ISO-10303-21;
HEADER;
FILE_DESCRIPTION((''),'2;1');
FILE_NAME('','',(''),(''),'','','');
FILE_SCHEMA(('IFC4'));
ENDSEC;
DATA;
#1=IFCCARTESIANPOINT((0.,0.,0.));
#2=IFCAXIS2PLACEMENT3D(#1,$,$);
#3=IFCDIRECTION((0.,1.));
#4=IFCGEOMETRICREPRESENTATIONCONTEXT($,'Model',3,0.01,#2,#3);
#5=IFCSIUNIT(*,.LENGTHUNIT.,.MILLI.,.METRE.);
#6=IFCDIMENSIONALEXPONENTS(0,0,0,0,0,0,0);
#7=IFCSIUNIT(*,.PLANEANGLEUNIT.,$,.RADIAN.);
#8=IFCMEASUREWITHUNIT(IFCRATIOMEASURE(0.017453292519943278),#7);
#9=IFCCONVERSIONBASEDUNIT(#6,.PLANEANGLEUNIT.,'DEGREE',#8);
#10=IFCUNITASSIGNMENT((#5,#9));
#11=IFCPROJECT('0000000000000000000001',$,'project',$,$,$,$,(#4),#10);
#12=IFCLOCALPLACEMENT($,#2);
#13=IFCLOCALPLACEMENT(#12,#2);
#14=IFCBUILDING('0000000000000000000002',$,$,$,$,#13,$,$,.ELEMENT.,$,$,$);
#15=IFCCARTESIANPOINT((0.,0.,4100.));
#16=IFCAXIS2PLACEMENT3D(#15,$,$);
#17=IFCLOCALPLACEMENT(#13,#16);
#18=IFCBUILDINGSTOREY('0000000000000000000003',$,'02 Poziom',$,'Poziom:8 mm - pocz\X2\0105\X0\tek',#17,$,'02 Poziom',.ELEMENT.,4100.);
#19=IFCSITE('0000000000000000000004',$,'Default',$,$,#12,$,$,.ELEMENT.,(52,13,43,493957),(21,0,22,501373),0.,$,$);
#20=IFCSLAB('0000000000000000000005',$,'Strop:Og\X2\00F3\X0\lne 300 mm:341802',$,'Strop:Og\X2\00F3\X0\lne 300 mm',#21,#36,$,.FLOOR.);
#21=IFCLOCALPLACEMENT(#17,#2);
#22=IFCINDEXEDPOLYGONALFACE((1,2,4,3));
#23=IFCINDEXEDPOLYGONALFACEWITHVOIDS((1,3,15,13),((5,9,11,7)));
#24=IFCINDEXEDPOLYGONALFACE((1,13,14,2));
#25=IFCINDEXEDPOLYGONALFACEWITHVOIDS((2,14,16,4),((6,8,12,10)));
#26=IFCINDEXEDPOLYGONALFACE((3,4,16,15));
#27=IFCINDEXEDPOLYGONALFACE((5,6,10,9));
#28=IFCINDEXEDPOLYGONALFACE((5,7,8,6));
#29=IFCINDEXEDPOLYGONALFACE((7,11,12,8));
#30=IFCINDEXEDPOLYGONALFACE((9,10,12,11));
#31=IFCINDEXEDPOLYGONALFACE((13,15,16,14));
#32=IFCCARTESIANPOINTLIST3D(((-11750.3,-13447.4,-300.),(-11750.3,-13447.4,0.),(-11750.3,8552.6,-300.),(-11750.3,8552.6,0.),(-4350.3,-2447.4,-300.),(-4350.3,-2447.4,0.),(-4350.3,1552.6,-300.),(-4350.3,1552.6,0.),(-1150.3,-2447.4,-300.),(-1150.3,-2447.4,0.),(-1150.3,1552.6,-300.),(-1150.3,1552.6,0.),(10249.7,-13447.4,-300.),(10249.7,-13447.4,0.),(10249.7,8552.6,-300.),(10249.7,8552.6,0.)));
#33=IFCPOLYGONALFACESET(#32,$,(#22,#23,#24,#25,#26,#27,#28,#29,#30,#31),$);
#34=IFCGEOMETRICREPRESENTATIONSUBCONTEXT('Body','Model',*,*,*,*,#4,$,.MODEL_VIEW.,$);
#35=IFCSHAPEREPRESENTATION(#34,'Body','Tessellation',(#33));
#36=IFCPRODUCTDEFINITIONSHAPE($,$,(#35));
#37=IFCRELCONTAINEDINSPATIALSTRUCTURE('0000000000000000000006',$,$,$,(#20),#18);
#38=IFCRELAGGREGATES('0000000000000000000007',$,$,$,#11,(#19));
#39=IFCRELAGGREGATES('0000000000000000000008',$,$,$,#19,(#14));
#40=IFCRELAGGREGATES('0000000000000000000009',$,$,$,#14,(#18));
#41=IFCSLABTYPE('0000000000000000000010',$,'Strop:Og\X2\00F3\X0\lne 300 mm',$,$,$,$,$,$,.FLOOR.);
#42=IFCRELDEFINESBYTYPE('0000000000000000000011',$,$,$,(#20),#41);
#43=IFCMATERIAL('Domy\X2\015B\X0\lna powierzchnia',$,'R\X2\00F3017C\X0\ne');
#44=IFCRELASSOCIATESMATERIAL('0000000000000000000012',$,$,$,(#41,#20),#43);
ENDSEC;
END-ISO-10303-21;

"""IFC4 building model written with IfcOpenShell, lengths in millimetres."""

from ifc_helpers import new_model, entity, si_unit, converted_unit, direction, frame, origin, place, context, subcontext, project, spatial, indexed_curve, outline, extrude, material, type_object, element, save


model = new_model("IFC4")

# Units and contexts
model_context = context("Model", 3, precision=0.01, world=origin(), true_north=direction((0.0, 1.0)))
body_context = subcontext(model_context, "Body", "Model", "MODEL_VIEW")
ifc_project = project(units=[si_unit("LENGTHUNIT", "METRE", prefix="MILLI"), converted_unit("PLANEANGLEUNIT", "DEGREE", entity("IfcRatioMeasure", 0.017453292519943278), si_unit("PLANEANGLEUNIT", "RADIAN"), dimensions=[0, 0, 0, 0, 0, 0, 0])], contexts=[model_context])

# Site, building, storey
site_placement = place(None, origin())
site = spatial("IfcSite", under=ifc_project, at=site_placement, Name="Default", CompositionType="ELEMENT", RefLatitude=(52, 13, 43, 493957), RefLongitude=(21, 0, 22, 501373), RefElevation=0.0)
building_placement = place(site_placement, origin())
building = spatial("IfcBuilding", under=site, at=building_placement, CompositionType="ELEMENT")
storey_placement = place(building_placement, frame((0.0, 0.0, 4100.0)))
storey = spatial("IfcBuildingStorey", under=building, at=storey_placement, Name="02 Poziom", ObjectType="Poziom:8 mm - początek", LongName="02 Poziom", CompositionType="ELEMENT", Elevation=4100.0)

# Slab, opening
ifc_material_1 = material(Name="Domyślna powierzchnia", Category="Różne")
slab_type = type_object("IfcSlabType", Name="Strop:Ogólne 300 mm", PredefinedType="FLOOR", material=ifc_material_1)
slab_placement = place(storey_placement, origin())
slab = element("IfcSlab", 1, at=slab_placement, inside=storey, type_object=slab_type, material=ifc_material_1, Name="Strop:Ogólne 300 mm:341802", ObjectType="Strop:Ogólne 300 mm", PredefinedType="FLOOR", context=body_context, shape_type="SweptSolid", body=[
    extrude(outline(indexed_curve([(-11000.0, -11000.0), (11000.0, -11000.0), (11000.0, 11000.0), (-11000.0, 11000.0), (-11000.0, -11000.0)], self_intersect=False), holes=[indexed_curve([(400.0, -4000.0), (400.0, 0.0), (3600.0, 0.0), (3600.0, -4000.0), (400.0, -4000.0)], self_intersect=False)]), frame((-750.3, -2447.4, -300.0), z_axis=(0.0, 0.0, 1.0), x_axis=(-1.0, 0.0, 0.0)), (0.0, 0.0, 1.0), 300.0),
])
opening_placement = place(slab_placement, origin())
element("IfcOpeningElement", 2, at=opening_placement, cuts=slab, PredefinedType="OPENING", context=body_context, shape_type="SweptSolid", body=[
    extrude(outline(indexed_curve([(-1600.0, -2000.0), (1600.0, -2000.0), (1600.0, 2000.0), (-1600.0, 2000.0), (-1600.0, -2000.0)], self_intersect=False)), frame((-2750.3, -447.4, -300.0), z_axis=(0.0, 0.0, 1.0), x_axis=(-1.0, 0.0, 0.0)), (0.0, 0.0, 1.0), 300.0),
])

save(model, "model.ifc")
